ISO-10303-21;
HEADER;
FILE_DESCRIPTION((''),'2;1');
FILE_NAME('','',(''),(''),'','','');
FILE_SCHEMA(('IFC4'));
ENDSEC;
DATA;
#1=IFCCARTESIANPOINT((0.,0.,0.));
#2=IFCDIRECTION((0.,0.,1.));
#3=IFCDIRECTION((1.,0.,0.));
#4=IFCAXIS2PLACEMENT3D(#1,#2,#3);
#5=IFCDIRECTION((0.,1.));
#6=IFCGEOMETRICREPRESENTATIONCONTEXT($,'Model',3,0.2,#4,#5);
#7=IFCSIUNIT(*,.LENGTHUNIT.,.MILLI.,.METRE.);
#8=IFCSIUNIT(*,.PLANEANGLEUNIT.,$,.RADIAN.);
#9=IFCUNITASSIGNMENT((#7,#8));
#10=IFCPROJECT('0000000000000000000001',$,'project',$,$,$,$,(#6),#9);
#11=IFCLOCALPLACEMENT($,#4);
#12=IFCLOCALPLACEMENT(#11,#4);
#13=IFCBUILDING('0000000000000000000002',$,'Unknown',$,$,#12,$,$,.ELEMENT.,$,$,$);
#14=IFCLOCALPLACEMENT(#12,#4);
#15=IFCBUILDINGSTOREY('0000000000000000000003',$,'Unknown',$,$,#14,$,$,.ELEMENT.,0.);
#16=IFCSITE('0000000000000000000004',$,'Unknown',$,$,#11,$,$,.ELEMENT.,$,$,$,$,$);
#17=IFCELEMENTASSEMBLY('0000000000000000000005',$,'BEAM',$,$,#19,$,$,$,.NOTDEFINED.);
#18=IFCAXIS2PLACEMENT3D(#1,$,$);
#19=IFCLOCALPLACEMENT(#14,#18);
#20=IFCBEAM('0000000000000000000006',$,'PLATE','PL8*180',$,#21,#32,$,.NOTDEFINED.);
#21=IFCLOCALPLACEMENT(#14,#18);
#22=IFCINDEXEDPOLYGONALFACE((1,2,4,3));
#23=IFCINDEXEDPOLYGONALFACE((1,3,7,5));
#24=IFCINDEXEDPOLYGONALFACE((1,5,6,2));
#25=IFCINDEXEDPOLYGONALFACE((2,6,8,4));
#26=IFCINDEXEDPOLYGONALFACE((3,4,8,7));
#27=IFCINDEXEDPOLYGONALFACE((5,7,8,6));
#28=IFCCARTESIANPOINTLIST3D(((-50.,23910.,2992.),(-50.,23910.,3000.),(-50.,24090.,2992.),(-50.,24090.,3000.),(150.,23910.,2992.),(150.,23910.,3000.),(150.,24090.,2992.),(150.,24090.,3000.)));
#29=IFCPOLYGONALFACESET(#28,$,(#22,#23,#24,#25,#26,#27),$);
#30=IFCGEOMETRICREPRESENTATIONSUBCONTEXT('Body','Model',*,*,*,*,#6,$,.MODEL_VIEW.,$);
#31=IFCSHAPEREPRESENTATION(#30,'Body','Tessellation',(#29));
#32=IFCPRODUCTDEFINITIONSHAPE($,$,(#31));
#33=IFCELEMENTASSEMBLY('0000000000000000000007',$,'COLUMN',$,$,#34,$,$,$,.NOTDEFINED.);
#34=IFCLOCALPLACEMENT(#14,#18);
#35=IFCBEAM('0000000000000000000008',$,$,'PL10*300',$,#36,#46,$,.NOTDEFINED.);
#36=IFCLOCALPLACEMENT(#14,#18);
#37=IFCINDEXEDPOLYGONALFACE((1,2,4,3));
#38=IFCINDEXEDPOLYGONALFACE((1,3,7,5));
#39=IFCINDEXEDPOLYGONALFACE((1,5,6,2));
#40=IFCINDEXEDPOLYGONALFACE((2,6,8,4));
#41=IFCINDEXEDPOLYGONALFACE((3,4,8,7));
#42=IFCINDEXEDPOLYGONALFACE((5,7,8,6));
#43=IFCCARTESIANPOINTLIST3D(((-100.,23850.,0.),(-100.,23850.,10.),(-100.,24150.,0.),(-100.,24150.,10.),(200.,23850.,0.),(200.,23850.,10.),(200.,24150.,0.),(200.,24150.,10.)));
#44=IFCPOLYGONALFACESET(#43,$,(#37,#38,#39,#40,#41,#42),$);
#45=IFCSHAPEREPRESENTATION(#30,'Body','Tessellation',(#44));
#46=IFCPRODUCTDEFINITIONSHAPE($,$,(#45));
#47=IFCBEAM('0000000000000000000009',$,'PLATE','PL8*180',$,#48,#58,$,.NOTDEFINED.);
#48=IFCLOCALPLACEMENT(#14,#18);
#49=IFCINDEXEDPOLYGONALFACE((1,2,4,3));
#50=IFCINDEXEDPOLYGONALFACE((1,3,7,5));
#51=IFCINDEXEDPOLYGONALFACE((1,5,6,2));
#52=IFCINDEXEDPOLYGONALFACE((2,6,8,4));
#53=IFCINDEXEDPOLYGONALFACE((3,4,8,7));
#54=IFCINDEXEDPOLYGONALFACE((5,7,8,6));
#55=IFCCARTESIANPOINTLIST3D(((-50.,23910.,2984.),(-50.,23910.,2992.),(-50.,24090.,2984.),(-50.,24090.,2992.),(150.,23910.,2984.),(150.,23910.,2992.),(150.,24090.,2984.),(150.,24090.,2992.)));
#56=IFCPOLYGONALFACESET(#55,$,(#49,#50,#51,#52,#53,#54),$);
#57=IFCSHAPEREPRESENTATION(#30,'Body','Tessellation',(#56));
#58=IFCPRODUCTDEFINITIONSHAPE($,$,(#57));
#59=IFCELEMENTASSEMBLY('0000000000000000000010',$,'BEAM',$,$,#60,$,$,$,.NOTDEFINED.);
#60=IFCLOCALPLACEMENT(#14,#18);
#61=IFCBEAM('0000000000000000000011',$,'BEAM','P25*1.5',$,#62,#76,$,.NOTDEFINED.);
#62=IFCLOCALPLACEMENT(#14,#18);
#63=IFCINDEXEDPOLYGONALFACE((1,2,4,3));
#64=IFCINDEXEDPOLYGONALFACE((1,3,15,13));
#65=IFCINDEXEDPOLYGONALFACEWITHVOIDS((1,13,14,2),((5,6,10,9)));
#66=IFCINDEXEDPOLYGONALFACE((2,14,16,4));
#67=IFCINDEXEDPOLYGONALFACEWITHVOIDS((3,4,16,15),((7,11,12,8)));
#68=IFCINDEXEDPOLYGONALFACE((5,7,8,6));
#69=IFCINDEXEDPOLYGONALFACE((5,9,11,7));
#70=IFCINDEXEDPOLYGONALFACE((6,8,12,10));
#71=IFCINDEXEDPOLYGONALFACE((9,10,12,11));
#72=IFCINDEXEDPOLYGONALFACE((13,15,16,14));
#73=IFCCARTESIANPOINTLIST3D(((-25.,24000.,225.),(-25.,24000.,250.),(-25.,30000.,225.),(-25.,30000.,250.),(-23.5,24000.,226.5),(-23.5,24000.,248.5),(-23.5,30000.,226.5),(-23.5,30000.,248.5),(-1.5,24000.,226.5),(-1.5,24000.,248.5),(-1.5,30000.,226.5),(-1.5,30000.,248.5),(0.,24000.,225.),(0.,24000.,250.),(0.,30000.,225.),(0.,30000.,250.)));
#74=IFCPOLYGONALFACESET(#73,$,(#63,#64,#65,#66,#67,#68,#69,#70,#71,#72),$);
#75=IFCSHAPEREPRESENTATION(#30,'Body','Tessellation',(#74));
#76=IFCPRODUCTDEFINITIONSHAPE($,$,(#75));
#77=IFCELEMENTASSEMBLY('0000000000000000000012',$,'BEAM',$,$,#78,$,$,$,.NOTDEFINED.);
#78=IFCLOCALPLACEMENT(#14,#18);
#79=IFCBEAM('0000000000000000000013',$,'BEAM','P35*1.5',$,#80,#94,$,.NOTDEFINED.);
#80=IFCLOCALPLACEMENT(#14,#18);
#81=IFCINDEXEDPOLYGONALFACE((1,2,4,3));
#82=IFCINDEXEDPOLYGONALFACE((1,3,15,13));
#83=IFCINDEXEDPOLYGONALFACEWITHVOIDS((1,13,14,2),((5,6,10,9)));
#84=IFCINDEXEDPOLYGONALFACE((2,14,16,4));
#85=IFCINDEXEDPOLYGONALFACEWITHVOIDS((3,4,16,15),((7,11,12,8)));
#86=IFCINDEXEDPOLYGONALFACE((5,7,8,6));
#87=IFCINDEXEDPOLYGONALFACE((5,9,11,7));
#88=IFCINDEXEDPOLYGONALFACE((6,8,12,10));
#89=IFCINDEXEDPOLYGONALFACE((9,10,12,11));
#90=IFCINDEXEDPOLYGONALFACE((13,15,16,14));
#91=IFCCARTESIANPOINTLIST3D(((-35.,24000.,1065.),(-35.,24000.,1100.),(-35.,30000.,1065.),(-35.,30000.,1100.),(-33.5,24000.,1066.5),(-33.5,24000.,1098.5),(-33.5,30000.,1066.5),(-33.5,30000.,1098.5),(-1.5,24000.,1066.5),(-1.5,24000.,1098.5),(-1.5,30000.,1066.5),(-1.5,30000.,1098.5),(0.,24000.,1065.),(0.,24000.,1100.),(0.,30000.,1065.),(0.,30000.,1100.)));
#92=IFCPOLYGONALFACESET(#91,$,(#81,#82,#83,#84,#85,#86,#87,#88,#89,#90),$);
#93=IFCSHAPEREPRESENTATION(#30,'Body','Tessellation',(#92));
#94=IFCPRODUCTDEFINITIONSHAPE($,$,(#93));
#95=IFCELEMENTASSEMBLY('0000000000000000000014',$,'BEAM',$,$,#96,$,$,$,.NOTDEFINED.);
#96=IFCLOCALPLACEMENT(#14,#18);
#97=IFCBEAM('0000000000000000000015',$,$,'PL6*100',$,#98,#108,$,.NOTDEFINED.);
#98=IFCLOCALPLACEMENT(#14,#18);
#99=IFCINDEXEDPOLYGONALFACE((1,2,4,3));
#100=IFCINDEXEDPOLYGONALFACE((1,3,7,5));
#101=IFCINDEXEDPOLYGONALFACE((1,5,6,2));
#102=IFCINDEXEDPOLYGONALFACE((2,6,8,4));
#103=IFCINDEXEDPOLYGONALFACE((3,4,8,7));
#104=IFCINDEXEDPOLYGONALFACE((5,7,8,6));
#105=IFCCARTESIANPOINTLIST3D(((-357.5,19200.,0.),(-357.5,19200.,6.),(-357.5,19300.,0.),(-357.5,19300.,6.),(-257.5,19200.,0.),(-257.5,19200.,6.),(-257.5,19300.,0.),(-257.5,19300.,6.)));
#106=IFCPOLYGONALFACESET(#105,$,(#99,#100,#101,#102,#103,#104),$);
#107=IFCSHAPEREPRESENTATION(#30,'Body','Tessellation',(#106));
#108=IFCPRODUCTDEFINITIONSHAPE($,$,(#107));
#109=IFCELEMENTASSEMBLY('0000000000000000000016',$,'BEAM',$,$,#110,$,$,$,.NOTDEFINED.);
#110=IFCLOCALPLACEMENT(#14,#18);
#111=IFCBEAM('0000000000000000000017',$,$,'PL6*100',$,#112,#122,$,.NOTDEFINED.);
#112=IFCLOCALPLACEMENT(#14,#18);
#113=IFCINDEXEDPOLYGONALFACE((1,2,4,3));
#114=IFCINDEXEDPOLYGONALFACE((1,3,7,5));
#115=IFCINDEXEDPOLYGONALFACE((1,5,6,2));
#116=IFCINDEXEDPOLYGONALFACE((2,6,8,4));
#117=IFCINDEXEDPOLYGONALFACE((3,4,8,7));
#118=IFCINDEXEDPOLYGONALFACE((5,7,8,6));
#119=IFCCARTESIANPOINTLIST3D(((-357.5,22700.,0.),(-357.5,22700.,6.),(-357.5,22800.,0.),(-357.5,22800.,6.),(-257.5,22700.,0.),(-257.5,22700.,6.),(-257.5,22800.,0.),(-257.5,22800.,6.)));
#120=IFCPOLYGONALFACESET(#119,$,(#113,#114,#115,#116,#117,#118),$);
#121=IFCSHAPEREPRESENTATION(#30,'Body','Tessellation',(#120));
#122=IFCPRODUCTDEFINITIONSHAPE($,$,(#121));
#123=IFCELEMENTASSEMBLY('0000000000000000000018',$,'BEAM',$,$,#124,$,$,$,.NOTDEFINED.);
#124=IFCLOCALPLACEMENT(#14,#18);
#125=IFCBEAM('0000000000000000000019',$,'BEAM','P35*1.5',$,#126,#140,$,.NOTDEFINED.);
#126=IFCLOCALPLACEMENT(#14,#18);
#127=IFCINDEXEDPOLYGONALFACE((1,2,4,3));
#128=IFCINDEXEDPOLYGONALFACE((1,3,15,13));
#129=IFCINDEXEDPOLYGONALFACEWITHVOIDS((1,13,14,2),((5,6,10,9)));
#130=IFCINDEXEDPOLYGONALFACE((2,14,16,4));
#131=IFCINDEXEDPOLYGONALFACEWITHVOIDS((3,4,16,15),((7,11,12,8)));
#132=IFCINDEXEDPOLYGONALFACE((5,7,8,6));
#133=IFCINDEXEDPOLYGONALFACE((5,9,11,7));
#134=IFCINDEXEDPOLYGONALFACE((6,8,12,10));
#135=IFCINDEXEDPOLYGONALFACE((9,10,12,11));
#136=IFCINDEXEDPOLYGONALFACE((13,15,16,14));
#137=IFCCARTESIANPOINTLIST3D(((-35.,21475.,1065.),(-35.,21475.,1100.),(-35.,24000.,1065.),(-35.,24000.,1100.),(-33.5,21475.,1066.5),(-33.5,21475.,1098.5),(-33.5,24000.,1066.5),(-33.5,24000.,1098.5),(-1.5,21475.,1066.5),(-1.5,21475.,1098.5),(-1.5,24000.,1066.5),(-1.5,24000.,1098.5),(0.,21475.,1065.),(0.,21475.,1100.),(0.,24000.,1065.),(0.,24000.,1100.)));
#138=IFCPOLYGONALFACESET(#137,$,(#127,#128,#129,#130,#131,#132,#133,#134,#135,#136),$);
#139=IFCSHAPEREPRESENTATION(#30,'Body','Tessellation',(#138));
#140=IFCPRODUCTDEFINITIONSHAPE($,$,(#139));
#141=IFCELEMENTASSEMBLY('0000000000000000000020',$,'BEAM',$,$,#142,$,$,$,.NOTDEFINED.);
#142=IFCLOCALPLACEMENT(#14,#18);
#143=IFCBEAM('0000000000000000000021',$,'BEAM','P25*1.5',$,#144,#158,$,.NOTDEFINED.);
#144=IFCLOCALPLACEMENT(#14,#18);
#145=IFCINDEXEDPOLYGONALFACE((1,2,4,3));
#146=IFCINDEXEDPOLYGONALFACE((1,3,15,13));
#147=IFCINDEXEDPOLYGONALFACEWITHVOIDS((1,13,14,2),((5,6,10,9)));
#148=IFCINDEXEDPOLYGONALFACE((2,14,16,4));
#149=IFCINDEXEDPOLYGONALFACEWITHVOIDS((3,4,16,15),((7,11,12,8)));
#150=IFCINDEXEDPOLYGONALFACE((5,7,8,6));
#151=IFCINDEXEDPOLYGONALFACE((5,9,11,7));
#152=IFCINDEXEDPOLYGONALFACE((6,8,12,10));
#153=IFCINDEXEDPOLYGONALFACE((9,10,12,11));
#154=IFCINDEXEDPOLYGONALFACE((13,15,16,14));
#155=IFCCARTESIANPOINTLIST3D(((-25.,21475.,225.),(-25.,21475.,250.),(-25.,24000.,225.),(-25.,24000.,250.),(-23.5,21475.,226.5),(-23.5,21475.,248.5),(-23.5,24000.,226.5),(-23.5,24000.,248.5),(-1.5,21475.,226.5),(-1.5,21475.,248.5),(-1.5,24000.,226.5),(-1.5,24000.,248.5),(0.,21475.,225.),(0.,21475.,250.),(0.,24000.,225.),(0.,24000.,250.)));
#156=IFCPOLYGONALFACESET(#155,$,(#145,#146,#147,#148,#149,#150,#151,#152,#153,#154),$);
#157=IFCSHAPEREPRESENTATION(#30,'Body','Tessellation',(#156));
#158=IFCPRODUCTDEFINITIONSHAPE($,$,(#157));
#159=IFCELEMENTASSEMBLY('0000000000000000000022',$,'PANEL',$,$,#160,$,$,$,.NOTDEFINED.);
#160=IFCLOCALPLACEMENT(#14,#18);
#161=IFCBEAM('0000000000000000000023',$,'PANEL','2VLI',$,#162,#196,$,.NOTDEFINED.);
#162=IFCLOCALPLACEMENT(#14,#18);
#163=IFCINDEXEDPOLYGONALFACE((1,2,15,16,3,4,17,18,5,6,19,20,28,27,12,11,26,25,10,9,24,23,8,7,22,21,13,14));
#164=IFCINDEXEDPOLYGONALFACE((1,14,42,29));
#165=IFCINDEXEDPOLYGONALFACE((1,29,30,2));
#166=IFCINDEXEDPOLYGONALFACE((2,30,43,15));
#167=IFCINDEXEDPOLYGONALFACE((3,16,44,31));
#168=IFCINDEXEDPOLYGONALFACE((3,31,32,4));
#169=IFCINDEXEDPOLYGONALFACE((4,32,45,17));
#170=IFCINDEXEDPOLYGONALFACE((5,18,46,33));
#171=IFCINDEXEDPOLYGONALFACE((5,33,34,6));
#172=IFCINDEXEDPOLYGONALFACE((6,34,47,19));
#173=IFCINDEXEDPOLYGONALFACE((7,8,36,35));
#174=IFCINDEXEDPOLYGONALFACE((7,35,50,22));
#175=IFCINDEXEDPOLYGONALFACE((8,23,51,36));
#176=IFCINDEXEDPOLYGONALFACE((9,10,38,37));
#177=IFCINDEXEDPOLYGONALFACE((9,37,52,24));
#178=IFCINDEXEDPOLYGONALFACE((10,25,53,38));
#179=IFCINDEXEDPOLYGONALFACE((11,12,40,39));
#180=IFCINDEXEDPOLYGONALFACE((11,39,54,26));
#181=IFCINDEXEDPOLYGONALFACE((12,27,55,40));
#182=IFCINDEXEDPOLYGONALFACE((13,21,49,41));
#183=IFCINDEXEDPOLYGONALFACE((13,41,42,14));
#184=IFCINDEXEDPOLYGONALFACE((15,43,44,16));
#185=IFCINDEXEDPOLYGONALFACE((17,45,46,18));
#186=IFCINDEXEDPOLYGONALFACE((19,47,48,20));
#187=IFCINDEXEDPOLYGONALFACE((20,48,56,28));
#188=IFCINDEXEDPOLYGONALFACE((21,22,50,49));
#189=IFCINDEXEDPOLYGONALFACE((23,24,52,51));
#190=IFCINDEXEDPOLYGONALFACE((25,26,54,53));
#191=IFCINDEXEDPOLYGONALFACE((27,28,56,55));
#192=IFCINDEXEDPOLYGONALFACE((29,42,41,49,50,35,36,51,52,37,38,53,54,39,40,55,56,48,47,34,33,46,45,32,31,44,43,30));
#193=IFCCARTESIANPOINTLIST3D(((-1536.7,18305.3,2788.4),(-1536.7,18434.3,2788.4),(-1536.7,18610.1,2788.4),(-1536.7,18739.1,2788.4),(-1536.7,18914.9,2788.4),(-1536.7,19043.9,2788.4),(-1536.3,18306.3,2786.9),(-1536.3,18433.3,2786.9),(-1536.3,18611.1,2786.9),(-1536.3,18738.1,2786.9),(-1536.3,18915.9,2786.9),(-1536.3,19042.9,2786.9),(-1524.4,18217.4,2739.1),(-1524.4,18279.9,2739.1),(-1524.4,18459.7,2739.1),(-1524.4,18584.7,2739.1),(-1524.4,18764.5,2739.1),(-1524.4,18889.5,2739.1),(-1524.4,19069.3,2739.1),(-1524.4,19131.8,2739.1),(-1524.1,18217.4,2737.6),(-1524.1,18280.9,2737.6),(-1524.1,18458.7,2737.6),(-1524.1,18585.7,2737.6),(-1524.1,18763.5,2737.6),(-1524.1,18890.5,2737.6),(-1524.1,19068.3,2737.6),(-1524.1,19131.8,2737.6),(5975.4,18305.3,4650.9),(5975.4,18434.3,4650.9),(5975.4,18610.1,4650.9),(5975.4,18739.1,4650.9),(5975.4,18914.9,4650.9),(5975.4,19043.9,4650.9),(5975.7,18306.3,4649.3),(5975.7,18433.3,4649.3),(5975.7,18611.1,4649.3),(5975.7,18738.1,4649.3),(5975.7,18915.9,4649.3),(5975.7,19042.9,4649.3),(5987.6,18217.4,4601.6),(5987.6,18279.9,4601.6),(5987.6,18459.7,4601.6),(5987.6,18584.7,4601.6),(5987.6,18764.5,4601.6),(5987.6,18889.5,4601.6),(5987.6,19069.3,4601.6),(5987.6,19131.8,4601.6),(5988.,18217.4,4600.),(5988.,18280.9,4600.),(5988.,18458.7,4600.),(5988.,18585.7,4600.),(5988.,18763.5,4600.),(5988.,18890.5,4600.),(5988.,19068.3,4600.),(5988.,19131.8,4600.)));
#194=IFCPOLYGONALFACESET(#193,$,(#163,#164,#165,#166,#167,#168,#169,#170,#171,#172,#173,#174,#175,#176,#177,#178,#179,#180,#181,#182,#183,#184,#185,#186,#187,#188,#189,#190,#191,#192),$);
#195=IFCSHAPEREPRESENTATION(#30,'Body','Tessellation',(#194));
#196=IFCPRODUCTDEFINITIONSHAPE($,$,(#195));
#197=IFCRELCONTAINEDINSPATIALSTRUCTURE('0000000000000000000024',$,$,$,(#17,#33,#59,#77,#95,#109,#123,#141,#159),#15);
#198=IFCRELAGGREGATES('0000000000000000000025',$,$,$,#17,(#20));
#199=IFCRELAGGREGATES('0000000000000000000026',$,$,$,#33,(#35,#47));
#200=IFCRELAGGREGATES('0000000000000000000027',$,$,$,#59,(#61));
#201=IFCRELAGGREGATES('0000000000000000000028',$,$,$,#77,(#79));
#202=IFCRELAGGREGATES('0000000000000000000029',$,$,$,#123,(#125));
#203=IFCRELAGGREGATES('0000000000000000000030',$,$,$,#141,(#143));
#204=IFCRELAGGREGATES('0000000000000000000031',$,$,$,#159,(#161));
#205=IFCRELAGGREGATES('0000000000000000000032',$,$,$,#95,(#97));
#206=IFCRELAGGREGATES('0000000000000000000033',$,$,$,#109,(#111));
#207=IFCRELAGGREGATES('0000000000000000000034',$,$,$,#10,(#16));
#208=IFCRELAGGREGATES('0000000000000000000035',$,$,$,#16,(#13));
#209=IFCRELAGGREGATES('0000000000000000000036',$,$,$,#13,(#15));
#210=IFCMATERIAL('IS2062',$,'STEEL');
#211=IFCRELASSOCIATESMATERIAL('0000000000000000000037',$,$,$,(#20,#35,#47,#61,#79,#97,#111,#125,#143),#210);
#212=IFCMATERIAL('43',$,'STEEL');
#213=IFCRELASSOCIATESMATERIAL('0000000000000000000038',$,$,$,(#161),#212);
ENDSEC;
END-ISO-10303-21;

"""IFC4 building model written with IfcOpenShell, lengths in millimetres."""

from ifc_helpers import new_model, si_unit, direction, frame, origin_with_axes, place, context, subcontext, project, spatial, line, indexed_curve, outline, extrude, material, element, aggregate, save


model = new_model("IFC4")

# Units and contexts
model_context = context("Model", 3, precision=0.2, world=origin_with_axes(), true_north=direction((0.0, 1.0)))
body_context = subcontext(model_context, "Body", "Model", "MODEL_VIEW")
ifc_project = project(units=[si_unit("LENGTHUNIT", "METRE", prefix="MILLI"), si_unit("PLANEANGLEUNIT", "RADIAN")], contexts=[model_context])

# Site, building, storey
site_placement = place(None, origin_with_axes())
site = spatial("IfcSite", under=ifc_project, at=site_placement, Name="Unknown", CompositionType="ELEMENT")
building_placement = place(site_placement, origin_with_axes())
building = spatial("IfcBuilding", under=site, at=building_placement, Name="Unknown", CompositionType="ELEMENT")
storey_placement = place(building_placement, origin_with_axes())
storey = spatial("IfcBuildingStorey", under=building, at=storey_placement, Name="Unknown", CompositionType="ELEMENT", Elevation=0.0)

# Element assembly, beam
assembly_1_placement = place(storey_placement, frame((-50.0, 24000.0, 3025.0), z_axis=(0.0, -1.0, 0.0), x_axis=(1.0, 0.0, 0.0)))
assembly_1 = element("IfcElementAssembly", 1, at=assembly_1_placement, inside=storey, Name="BEAM", PredefinedType="NOTDEFINED")
ifc_material_1 = material(Name="IS2062", Category="STEEL")
beam_1_placement = place(assembly_1_placement, frame((0.0, -29.0, 0.0), z_axis=(0.0, -1.0, 0.0), x_axis=(1.0, 0.0, 0.0)))
beam_1 = element("IfcBeam", 2, at=beam_1_placement, material=ifc_material_1, Name="PLATE", Description="PL8*180", PredefinedType="NOTDEFINED", context=body_context, shape_type="SolidModel", body=[
    extrude(outline(indexed_curve([(-4.0, -90.0), (4.0, -90.0), (4.0, 90.0), (-4.0, 90.0)], segments=[line(1, 2, 3, 4, 1)])), frame((0.0, 0.0, 0.0), z_axis=(-1.0, 0.0, 0.0), x_axis=(0.0, 0.0, 1.0)), (0.0, 0.0, -1.0), 200.0),
])
aggregate(assembly_1, [beam_1])

# Element assembly, beams
assembly_2_placement = place(storey_placement, frame((50.0, 24000.0, 0.0), z_axis=(0.0, 1.0, 0.0), x_axis=(0.0, 0.0, 1.0)))
assembly_2 = element("IfcElementAssembly", 3, at=assembly_2_placement, inside=storey, Name="COLUMN", PredefinedType="NOTDEFINED")
beam_2_placement = place(assembly_2_placement, frame((5.0, -150.0, 0.0), z_axis=(1.0, 0.0, 0.0), x_axis=(0.0, 1.0, 0.0)))
beam_2 = element("IfcBeam", 4, at=beam_2_placement, material=ifc_material_1, Description="PL10*300", PredefinedType="NOTDEFINED", context=body_context, shape_type="SolidModel", body=[
    extrude(outline(indexed_curve([(-5.0, -150.0), (5.0, -150.0), (5.0, 150.0), (-5.0, 150.0)], segments=[line(1, 2, 3, 4, 1)])), frame((0.0, 0.0, 0.0), z_axis=(-1.0, 0.0, 0.0), x_axis=(0.0, 0.0, 1.0)), (0.0, 0.0, -1.0), 300.0),
])
beam_3_placement = place(assembly_2_placement, frame((2988.0, -100.0, 0.0), z_axis=(-1.0, 0.0, 0.0), x_axis=(0.0, 1.0, 0.0)))
beam_3 = element("IfcBeam", 5, at=beam_3_placement, material=ifc_material_1, Name="PLATE", Description="PL8*180", PredefinedType="NOTDEFINED", context=body_context, shape_type="SolidModel", body=[
    extrude(outline(indexed_curve([(-4.0, -90.0), (4.0, -90.0), (4.0, 90.0), (-4.0, 90.0)], segments=[line(1, 2, 3, 4, 1)])), frame((0.0, 0.0, 0.0), z_axis=(-1.0, 0.0, 0.0), x_axis=(0.0, 0.0, 1.0)), (0.0, 0.0, -1.0), 200.0),
])
aggregate(assembly_2, [beam_2, beam_3])

# Element assemblies, beams
assembly_3_placement = place(storey_placement, frame((-12.5, 24000.0, 237.5), z_axis=(1.0, 0.0, 0.0), x_axis=(0.0, 1.0, 0.0)))
assembly_3 = element("IfcElementAssembly", 6, at=assembly_3_placement, inside=storey, Name="BEAM", PredefinedType="NOTDEFINED")
beam_4_placement = place(assembly_3_placement, origin_with_axes())
beam_4 = element("IfcBeam", 7, at=beam_4_placement, material=ifc_material_1, Name="BEAM", Description="P25*1.5", PredefinedType="NOTDEFINED", context=body_context, shape_type="SolidModel", body=[
    extrude(outline(indexed_curve([(-12.5, -12.5), (12.5, -12.5), (12.5, 12.5), (-12.5, 12.5)], segments=[line(1, 2, 3, 4, 1)]), holes=[indexed_curve([(-11.0, -11.0), (-11.0, 11.0), (11.0, 11.0), (11.0, -11.0)], segments=[line(1, 2, 3, 4, 1)])]), frame((0.0, 0.0, 0.0), z_axis=(-1.0, 0.0, 0.0), x_axis=(0.0, 0.0, 1.0)), (0.0, 0.0, -1.0), 6000.0),
])
aggregate(assembly_3, [beam_4])
assembly_4_placement = place(storey_placement, frame((-17.5, 24000.0, 1082.5), z_axis=(1.0, 0.0, 0.0), x_axis=(0.0, 1.0, 0.0)))
assembly_4 = element("IfcElementAssembly", 8, at=assembly_4_placement, inside=storey, Name="BEAM", PredefinedType="NOTDEFINED")
beam_5_placement = place(assembly_4_placement, origin_with_axes())
beam_5 = element("IfcBeam", 9, at=beam_5_placement, material=ifc_material_1, Name="BEAM", Description="P35*1.5", PredefinedType="NOTDEFINED", context=body_context, shape_type="SolidModel", body=[
    extrude(outline(indexed_curve([(-17.5, -17.5), (17.5, -17.5), (17.5, 17.5), (-17.5, 17.5)], segments=[line(1, 2, 3, 4, 1)]), holes=[indexed_curve([(-16.0, -16.0), (-16.0, 16.0), (16.0, 16.0), (16.0, -16.0)], segments=[line(1, 2, 3, 4, 1)])]), frame((0.0, 0.0, 0.0), z_axis=(-1.0, 0.0, 0.0), x_axis=(0.0, 0.0, 1.0)), (0.0, 0.0, -1.0), 6000.0),
])
aggregate(assembly_4, [beam_5])
assembly_5_placement = place(storey_placement, frame((-307.5, 19250.0, 700.0), z_axis=(0.0, 1.0, 0.0), x_axis=(0.0, 0.0, -1.0)))
assembly_5 = element("IfcElementAssembly", 10, at=assembly_5_placement, inside=storey, Name="BEAM", PredefinedType="NOTDEFINED")
beam_6_placement = place(assembly_5_placement, frame((697.0, -50.0, 0.0), z_axis=(-1.0, 0.0, 0.0), x_axis=(0.0, 1.0, 0.0)))
beam_6 = element("IfcBeam", 11, at=beam_6_placement, material=ifc_material_1, Description="PL6*100", PredefinedType="NOTDEFINED", context=body_context, shape_type="SolidModel", body=[
    extrude(outline(indexed_curve([(-3.0, -50.0), (3.0, -50.0), (3.0, 50.0), (-3.0, 50.0)], segments=[line(1, 2, 3, 4, 1)])), frame((0.0, 0.0, 0.0), z_axis=(-1.0, 0.0, 0.0), x_axis=(0.0, 0.0, 1.0)), (0.0, 0.0, -1.0), 100.0),
])
assembly_6_placement = place(storey_placement, frame((-307.5, 22750.0, 700.0), z_axis=(0.0, 1.0, 0.0), x_axis=(0.0, 0.0, -1.0)))
assembly_6 = element("IfcElementAssembly", 12, at=assembly_6_placement, inside=storey, Name="BEAM", PredefinedType="NOTDEFINED")
beam_7_placement = place(assembly_6_placement, frame((697.0, -50.0, 0.0), z_axis=(-1.0, 0.0, 0.0), x_axis=(0.0, 1.0, 0.0)))
beam_7 = element("IfcBeam", 13, at=beam_7_placement, material=ifc_material_1, Description="PL6*100", PredefinedType="NOTDEFINED", context=body_context, shape_type="SolidModel", body=[
    extrude(outline(indexed_curve([(-3.0, -50.0), (3.0, -50.0), (3.0, 50.0), (-3.0, 50.0)], segments=[line(1, 2, 3, 4, 1)])), frame((0.0, 0.0, 0.0), z_axis=(-1.0, 0.0, 0.0), x_axis=(0.0, 0.0, 1.0)), (0.0, 0.0, -1.0), 100.0),
])
assembly_7_placement = place(storey_placement, frame((-17.5, 21475.0, 1082.5), z_axis=(1.0, 0.0, 0.0), x_axis=(0.0, 1.0, 0.0)))
assembly_7 = element("IfcElementAssembly", 14, at=assembly_7_placement, inside=storey, Name="BEAM", PredefinedType="NOTDEFINED")
beam_8_placement = place(assembly_7_placement, origin_with_axes())
beam_8 = element("IfcBeam", 15, at=beam_8_placement, material=ifc_material_1, Name="BEAM", Description="P35*1.5", PredefinedType="NOTDEFINED", context=body_context, shape_type="SolidModel", body=[
    extrude(outline(indexed_curve([(-17.5, -17.5), (17.5, -17.5), (17.5, 17.5), (-17.5, 17.5)], segments=[line(1, 2, 3, 4, 1)]), holes=[indexed_curve([(-16.0, -16.0), (-16.0, 16.0), (16.0, 16.0), (16.0, -16.0)], segments=[line(1, 2, 3, 4, 1)])]), frame((0.0, 0.0, 0.0), z_axis=(-1.0, 0.0, 0.0), x_axis=(0.0, 0.0, 1.0)), (0.0, 0.0, -1.0), 2525.0),
])
aggregate(assembly_7, [beam_8])
assembly_8_placement = place(storey_placement, frame((-12.5, 21475.0, 237.5), z_axis=(1.0, 0.0, 0.0), x_axis=(0.0, 1.0, 0.0)))
assembly_8 = element("IfcElementAssembly", 16, at=assembly_8_placement, inside=storey, Name="BEAM", PredefinedType="NOTDEFINED")
beam_9_placement = place(assembly_8_placement, origin_with_axes())
beam_9 = element("IfcBeam", 17, at=beam_9_placement, material=ifc_material_1, Name="BEAM", Description="P25*1.5", PredefinedType="NOTDEFINED", context=body_context, shape_type="SolidModel", body=[
    extrude(outline(indexed_curve([(-12.5, -12.5), (12.5, -12.5), (12.5, 12.5), (-12.5, 12.5)], segments=[line(1, 2, 3, 4, 1)]), holes=[indexed_curve([(-11.0, -11.0), (-11.0, 11.0), (11.0, 11.0), (11.0, -11.0)], segments=[line(1, 2, 3, 4, 1)])]), frame((0.0, 0.0, 0.0), z_axis=(-1.0, 0.0, 0.0), x_axis=(0.0, 0.0, 1.0)), (0.0, 0.0, -1.0), 2525.0),
])
aggregate(assembly_8, [beam_9])
assembly_9_placement = place(storey_placement, frame((-1530.4, 18674.6, 2763.0), z_axis=(0.0, -1.0, 0.0), x_axis=(0.970613, 0.0, 0.240648)))
assembly_9 = element("IfcElementAssembly", 18, at=assembly_9_placement, inside=storey, Name="PANEL", PredefinedType="NOTDEFINED")
ifc_material_2 = material(Name="43", Category="STEEL")
beam_10_placement = place(assembly_9_placement, origin_with_axes())
beam_10 = element("IfcBeam", 19, at=beam_10_placement, material=ifc_material_2, Name="PANEL", Description="2VLI", PredefinedType="NOTDEFINED", context=body_context, shape_type="SolidModel", body=[
    extrude(outline(indexed_curve([(457.2, -26.2), (457.2, -24.6), (394.7, -24.6), (369.3, 26.2), (240.3, 26.2), (214.9, -24.6), (89.9, -24.6), (64.5, 26.2), (-64.5, 26.2), (-89.9, -24.6), (-214.9, -24.6), (-240.3, 26.2), (-369.3, 26.2), (-394.7, -24.6), (-457.2, -24.6), (-457.2, -26.2), (-393.7, -26.2), (-368.3, 24.6), (-241.3, 24.6), (-215.9, -26.2), (-88.9, -26.2), (-63.5, 24.6), (63.5, 24.6), (88.9, -26.2), (215.9, -26.2), (241.3, 24.6), (368.3, 24.6), (393.7, -26.2)], segments=[line(1, 2, 3, 4, 5, 6, 7, 8, 9, 10, 11, 12, 13, 14, 15, 16, 17, 18, 19, 20, 21, 22, 23, 24, 25, 26, 27, 28, 1)])), frame((0.0, 0.0, 0.0), z_axis=(-1.0, 0.0, 0.0), x_axis=(0.0, 0.0, 1.0)), (0.0, 0.0, -1.0), 7739.5),
])
aggregate(assembly_9, [beam_10])

aggregate(assembly_5, [beam_6])
aggregate(assembly_6, [beam_7])

save(model, "model.ifc")
